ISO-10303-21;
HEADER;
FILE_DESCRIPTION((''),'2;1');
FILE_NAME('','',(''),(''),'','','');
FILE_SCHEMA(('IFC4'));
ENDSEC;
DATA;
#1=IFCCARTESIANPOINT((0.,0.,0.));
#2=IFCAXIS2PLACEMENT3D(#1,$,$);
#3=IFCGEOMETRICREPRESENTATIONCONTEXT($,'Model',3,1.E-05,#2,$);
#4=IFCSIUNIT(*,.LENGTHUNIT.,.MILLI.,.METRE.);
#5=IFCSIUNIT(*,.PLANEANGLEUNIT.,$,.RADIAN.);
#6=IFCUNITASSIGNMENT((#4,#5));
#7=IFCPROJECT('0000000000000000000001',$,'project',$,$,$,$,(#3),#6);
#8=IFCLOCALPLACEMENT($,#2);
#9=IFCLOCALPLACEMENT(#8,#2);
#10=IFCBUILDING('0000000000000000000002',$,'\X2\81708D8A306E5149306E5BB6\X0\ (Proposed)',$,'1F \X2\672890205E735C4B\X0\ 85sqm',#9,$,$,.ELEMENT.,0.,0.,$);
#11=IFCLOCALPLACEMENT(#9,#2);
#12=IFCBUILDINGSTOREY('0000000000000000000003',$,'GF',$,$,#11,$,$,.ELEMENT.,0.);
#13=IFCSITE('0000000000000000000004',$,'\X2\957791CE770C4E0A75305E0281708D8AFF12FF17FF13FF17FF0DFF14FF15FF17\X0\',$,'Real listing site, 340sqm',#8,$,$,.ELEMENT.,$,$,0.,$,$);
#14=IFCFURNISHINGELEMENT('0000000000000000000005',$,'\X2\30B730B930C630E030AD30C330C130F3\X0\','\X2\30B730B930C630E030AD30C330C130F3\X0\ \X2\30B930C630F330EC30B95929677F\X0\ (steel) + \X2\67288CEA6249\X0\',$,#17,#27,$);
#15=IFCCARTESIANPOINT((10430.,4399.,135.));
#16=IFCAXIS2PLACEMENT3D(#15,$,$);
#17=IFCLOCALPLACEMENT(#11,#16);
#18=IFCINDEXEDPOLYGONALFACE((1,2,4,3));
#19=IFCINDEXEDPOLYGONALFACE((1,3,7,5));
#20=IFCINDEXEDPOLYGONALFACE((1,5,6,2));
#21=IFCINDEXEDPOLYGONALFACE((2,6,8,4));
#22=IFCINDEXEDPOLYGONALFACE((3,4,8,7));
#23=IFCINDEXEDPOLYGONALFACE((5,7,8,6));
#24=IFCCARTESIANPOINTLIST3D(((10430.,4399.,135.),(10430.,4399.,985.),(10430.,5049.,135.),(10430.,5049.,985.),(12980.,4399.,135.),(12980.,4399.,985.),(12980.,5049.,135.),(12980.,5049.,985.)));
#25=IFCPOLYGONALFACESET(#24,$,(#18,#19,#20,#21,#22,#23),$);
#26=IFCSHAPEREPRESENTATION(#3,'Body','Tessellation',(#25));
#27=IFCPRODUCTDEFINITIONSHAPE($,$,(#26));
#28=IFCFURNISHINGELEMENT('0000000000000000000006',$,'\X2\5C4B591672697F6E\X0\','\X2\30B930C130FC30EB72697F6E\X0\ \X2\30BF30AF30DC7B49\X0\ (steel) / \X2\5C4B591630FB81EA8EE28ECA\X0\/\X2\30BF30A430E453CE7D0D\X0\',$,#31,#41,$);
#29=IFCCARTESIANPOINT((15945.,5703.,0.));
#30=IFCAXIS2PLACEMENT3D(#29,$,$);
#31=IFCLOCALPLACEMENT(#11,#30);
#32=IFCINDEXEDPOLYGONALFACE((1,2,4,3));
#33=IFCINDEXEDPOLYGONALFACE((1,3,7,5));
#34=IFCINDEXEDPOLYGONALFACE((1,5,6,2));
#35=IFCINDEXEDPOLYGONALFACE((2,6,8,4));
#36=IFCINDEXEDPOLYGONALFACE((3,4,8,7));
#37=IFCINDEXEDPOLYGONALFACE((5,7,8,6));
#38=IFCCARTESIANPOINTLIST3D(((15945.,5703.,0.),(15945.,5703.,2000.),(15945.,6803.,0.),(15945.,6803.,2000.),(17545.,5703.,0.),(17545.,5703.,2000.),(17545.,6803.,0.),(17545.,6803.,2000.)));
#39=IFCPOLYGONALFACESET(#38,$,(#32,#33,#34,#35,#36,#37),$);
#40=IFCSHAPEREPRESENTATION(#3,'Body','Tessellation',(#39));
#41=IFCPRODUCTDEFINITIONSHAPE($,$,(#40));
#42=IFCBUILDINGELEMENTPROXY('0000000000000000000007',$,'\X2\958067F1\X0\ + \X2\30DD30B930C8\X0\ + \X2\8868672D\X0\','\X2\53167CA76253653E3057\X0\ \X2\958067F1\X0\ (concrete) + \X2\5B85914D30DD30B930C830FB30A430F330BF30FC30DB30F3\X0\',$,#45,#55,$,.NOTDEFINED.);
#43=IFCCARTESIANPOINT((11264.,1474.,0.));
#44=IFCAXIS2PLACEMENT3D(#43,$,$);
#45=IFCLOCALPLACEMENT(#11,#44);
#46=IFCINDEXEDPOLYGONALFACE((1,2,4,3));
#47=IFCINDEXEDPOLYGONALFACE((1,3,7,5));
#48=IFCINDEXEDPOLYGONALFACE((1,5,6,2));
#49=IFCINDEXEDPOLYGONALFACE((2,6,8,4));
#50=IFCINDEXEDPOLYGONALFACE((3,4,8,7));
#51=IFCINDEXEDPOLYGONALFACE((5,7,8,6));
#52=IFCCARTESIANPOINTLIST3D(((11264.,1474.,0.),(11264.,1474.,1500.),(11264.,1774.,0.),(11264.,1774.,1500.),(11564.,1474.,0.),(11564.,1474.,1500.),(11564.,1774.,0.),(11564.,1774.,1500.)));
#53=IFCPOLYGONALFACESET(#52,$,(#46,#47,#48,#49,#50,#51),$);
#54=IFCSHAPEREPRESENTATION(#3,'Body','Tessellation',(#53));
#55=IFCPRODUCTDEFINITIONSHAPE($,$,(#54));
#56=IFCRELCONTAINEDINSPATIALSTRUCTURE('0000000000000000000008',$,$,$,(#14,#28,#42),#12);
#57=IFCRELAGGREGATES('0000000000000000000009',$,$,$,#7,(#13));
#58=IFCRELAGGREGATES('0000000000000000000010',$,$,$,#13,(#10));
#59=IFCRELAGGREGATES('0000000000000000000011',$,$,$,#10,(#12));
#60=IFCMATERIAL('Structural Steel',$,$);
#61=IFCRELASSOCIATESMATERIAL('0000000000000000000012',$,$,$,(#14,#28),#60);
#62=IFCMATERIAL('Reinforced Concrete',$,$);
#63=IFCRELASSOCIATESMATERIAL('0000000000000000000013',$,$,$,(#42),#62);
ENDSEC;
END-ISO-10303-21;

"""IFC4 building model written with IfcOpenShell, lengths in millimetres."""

from ifc_helpers import new_model, si_unit, frame, frame_2d, origin, place, context, project, spatial, rectangle, extrude, material, element, save


model = new_model("IFC4")

# Units and contexts
model_context = context("Model", 3, precision=1e-05, world=origin())
ifc_project = project(units=[si_unit("LENGTHUNIT", "METRE", prefix="MILLI"), si_unit("PLANEANGLEUNIT", "RADIAN")], contexts=[model_context])

# Site, building, storey
site_placement = place(None, origin())
site = spatial("IfcSite", under=ifc_project, at=site_placement, Name="長野県上田市腰越２７３７－４５７", ObjectType="Real listing site, 340sqm", CompositionType="ELEMENT", RefElevation=0.0)
building_placement = place(site_placement, origin())
building = spatial("IfcBuilding", under=site, at=building_placement, Name="腰越の光の家 (Proposed)", ObjectType="1F 木造平屋 85sqm", CompositionType="ELEMENT", ElevationOfRefHeight=0.0, ElevationOfTerrain=0.0)
storey_placement = place(building_placement, origin())
storey = spatial("IfcBuildingStorey", under=building, at=storey_placement, Name="GF", CompositionType="ELEMENT", Elevation=0.0)

# Shared definitions
ifc_material_1 = material(Name="Reinforced Concrete")

# Shared definitions
ifc_material_2 = material(Name="Structural Steel")

# Furnishing elements
furnishing_1_placement = place(storey_placement, frame((10430.0, 4399.0, 135.0)))
element("IfcFurnishingElement", 1, at=furnishing_1_placement, inside=storey, material=ifc_material_2, Name="システムキッチン", Description="システムキッチン ステンレス天板 (steel) + 木質扉", context=model_context, shape_type="SweptSolid", body=[
    extrude(rectangle(XDim=2550.0, YDim=650.0, at=frame_2d((1275.0, 325.0))), frame((10430.0, 4399.0, 135.0)), (0.0, 0.0, 1.0), 850.0),
])
furnishing_2_placement = place(storey_placement, frame((15945.0, 5703.0, 0.0)))
element("IfcFurnishingElement", 2, at=furnishing_2_placement, inside=storey, material=ifc_material_2, Name="屋外物置", Description="スチール物置 タクボ等 (steel) / 屋外・自転車/タイヤ収納", context=model_context, shape_type="SweptSolid", body=[
    extrude(rectangle(XDim=1600.0, YDim=1100.0, at=frame_2d((800.0, 550.0))), frame((15945.0, 5703.0, 0.0)), (0.0, 0.0, 1.0), 2000.0),
])

# Building element proxy
proxy_placement = place(storey_placement, frame((11264.0, 1474.0, 0.0)))
element("IfcBuildingElementProxy", 3, at=proxy_placement, inside=storey, material=ifc_material_1, Name="門柱 + ポスト + 表札", Description="化粧打放し 門柱 (concrete) + 宅配ポスト・インターホン", PredefinedType="NOTDEFINED", context=model_context, shape_type="SweptSolid", body=[
    extrude(rectangle(XDim=300.0, YDim=300.0, at=frame_2d((150.0, 150.0))), frame((11264.0, 1474.0, 0.0)), (0.0, 0.0, 1.0), 1500.0),
])

save(model, "model.ifc")
